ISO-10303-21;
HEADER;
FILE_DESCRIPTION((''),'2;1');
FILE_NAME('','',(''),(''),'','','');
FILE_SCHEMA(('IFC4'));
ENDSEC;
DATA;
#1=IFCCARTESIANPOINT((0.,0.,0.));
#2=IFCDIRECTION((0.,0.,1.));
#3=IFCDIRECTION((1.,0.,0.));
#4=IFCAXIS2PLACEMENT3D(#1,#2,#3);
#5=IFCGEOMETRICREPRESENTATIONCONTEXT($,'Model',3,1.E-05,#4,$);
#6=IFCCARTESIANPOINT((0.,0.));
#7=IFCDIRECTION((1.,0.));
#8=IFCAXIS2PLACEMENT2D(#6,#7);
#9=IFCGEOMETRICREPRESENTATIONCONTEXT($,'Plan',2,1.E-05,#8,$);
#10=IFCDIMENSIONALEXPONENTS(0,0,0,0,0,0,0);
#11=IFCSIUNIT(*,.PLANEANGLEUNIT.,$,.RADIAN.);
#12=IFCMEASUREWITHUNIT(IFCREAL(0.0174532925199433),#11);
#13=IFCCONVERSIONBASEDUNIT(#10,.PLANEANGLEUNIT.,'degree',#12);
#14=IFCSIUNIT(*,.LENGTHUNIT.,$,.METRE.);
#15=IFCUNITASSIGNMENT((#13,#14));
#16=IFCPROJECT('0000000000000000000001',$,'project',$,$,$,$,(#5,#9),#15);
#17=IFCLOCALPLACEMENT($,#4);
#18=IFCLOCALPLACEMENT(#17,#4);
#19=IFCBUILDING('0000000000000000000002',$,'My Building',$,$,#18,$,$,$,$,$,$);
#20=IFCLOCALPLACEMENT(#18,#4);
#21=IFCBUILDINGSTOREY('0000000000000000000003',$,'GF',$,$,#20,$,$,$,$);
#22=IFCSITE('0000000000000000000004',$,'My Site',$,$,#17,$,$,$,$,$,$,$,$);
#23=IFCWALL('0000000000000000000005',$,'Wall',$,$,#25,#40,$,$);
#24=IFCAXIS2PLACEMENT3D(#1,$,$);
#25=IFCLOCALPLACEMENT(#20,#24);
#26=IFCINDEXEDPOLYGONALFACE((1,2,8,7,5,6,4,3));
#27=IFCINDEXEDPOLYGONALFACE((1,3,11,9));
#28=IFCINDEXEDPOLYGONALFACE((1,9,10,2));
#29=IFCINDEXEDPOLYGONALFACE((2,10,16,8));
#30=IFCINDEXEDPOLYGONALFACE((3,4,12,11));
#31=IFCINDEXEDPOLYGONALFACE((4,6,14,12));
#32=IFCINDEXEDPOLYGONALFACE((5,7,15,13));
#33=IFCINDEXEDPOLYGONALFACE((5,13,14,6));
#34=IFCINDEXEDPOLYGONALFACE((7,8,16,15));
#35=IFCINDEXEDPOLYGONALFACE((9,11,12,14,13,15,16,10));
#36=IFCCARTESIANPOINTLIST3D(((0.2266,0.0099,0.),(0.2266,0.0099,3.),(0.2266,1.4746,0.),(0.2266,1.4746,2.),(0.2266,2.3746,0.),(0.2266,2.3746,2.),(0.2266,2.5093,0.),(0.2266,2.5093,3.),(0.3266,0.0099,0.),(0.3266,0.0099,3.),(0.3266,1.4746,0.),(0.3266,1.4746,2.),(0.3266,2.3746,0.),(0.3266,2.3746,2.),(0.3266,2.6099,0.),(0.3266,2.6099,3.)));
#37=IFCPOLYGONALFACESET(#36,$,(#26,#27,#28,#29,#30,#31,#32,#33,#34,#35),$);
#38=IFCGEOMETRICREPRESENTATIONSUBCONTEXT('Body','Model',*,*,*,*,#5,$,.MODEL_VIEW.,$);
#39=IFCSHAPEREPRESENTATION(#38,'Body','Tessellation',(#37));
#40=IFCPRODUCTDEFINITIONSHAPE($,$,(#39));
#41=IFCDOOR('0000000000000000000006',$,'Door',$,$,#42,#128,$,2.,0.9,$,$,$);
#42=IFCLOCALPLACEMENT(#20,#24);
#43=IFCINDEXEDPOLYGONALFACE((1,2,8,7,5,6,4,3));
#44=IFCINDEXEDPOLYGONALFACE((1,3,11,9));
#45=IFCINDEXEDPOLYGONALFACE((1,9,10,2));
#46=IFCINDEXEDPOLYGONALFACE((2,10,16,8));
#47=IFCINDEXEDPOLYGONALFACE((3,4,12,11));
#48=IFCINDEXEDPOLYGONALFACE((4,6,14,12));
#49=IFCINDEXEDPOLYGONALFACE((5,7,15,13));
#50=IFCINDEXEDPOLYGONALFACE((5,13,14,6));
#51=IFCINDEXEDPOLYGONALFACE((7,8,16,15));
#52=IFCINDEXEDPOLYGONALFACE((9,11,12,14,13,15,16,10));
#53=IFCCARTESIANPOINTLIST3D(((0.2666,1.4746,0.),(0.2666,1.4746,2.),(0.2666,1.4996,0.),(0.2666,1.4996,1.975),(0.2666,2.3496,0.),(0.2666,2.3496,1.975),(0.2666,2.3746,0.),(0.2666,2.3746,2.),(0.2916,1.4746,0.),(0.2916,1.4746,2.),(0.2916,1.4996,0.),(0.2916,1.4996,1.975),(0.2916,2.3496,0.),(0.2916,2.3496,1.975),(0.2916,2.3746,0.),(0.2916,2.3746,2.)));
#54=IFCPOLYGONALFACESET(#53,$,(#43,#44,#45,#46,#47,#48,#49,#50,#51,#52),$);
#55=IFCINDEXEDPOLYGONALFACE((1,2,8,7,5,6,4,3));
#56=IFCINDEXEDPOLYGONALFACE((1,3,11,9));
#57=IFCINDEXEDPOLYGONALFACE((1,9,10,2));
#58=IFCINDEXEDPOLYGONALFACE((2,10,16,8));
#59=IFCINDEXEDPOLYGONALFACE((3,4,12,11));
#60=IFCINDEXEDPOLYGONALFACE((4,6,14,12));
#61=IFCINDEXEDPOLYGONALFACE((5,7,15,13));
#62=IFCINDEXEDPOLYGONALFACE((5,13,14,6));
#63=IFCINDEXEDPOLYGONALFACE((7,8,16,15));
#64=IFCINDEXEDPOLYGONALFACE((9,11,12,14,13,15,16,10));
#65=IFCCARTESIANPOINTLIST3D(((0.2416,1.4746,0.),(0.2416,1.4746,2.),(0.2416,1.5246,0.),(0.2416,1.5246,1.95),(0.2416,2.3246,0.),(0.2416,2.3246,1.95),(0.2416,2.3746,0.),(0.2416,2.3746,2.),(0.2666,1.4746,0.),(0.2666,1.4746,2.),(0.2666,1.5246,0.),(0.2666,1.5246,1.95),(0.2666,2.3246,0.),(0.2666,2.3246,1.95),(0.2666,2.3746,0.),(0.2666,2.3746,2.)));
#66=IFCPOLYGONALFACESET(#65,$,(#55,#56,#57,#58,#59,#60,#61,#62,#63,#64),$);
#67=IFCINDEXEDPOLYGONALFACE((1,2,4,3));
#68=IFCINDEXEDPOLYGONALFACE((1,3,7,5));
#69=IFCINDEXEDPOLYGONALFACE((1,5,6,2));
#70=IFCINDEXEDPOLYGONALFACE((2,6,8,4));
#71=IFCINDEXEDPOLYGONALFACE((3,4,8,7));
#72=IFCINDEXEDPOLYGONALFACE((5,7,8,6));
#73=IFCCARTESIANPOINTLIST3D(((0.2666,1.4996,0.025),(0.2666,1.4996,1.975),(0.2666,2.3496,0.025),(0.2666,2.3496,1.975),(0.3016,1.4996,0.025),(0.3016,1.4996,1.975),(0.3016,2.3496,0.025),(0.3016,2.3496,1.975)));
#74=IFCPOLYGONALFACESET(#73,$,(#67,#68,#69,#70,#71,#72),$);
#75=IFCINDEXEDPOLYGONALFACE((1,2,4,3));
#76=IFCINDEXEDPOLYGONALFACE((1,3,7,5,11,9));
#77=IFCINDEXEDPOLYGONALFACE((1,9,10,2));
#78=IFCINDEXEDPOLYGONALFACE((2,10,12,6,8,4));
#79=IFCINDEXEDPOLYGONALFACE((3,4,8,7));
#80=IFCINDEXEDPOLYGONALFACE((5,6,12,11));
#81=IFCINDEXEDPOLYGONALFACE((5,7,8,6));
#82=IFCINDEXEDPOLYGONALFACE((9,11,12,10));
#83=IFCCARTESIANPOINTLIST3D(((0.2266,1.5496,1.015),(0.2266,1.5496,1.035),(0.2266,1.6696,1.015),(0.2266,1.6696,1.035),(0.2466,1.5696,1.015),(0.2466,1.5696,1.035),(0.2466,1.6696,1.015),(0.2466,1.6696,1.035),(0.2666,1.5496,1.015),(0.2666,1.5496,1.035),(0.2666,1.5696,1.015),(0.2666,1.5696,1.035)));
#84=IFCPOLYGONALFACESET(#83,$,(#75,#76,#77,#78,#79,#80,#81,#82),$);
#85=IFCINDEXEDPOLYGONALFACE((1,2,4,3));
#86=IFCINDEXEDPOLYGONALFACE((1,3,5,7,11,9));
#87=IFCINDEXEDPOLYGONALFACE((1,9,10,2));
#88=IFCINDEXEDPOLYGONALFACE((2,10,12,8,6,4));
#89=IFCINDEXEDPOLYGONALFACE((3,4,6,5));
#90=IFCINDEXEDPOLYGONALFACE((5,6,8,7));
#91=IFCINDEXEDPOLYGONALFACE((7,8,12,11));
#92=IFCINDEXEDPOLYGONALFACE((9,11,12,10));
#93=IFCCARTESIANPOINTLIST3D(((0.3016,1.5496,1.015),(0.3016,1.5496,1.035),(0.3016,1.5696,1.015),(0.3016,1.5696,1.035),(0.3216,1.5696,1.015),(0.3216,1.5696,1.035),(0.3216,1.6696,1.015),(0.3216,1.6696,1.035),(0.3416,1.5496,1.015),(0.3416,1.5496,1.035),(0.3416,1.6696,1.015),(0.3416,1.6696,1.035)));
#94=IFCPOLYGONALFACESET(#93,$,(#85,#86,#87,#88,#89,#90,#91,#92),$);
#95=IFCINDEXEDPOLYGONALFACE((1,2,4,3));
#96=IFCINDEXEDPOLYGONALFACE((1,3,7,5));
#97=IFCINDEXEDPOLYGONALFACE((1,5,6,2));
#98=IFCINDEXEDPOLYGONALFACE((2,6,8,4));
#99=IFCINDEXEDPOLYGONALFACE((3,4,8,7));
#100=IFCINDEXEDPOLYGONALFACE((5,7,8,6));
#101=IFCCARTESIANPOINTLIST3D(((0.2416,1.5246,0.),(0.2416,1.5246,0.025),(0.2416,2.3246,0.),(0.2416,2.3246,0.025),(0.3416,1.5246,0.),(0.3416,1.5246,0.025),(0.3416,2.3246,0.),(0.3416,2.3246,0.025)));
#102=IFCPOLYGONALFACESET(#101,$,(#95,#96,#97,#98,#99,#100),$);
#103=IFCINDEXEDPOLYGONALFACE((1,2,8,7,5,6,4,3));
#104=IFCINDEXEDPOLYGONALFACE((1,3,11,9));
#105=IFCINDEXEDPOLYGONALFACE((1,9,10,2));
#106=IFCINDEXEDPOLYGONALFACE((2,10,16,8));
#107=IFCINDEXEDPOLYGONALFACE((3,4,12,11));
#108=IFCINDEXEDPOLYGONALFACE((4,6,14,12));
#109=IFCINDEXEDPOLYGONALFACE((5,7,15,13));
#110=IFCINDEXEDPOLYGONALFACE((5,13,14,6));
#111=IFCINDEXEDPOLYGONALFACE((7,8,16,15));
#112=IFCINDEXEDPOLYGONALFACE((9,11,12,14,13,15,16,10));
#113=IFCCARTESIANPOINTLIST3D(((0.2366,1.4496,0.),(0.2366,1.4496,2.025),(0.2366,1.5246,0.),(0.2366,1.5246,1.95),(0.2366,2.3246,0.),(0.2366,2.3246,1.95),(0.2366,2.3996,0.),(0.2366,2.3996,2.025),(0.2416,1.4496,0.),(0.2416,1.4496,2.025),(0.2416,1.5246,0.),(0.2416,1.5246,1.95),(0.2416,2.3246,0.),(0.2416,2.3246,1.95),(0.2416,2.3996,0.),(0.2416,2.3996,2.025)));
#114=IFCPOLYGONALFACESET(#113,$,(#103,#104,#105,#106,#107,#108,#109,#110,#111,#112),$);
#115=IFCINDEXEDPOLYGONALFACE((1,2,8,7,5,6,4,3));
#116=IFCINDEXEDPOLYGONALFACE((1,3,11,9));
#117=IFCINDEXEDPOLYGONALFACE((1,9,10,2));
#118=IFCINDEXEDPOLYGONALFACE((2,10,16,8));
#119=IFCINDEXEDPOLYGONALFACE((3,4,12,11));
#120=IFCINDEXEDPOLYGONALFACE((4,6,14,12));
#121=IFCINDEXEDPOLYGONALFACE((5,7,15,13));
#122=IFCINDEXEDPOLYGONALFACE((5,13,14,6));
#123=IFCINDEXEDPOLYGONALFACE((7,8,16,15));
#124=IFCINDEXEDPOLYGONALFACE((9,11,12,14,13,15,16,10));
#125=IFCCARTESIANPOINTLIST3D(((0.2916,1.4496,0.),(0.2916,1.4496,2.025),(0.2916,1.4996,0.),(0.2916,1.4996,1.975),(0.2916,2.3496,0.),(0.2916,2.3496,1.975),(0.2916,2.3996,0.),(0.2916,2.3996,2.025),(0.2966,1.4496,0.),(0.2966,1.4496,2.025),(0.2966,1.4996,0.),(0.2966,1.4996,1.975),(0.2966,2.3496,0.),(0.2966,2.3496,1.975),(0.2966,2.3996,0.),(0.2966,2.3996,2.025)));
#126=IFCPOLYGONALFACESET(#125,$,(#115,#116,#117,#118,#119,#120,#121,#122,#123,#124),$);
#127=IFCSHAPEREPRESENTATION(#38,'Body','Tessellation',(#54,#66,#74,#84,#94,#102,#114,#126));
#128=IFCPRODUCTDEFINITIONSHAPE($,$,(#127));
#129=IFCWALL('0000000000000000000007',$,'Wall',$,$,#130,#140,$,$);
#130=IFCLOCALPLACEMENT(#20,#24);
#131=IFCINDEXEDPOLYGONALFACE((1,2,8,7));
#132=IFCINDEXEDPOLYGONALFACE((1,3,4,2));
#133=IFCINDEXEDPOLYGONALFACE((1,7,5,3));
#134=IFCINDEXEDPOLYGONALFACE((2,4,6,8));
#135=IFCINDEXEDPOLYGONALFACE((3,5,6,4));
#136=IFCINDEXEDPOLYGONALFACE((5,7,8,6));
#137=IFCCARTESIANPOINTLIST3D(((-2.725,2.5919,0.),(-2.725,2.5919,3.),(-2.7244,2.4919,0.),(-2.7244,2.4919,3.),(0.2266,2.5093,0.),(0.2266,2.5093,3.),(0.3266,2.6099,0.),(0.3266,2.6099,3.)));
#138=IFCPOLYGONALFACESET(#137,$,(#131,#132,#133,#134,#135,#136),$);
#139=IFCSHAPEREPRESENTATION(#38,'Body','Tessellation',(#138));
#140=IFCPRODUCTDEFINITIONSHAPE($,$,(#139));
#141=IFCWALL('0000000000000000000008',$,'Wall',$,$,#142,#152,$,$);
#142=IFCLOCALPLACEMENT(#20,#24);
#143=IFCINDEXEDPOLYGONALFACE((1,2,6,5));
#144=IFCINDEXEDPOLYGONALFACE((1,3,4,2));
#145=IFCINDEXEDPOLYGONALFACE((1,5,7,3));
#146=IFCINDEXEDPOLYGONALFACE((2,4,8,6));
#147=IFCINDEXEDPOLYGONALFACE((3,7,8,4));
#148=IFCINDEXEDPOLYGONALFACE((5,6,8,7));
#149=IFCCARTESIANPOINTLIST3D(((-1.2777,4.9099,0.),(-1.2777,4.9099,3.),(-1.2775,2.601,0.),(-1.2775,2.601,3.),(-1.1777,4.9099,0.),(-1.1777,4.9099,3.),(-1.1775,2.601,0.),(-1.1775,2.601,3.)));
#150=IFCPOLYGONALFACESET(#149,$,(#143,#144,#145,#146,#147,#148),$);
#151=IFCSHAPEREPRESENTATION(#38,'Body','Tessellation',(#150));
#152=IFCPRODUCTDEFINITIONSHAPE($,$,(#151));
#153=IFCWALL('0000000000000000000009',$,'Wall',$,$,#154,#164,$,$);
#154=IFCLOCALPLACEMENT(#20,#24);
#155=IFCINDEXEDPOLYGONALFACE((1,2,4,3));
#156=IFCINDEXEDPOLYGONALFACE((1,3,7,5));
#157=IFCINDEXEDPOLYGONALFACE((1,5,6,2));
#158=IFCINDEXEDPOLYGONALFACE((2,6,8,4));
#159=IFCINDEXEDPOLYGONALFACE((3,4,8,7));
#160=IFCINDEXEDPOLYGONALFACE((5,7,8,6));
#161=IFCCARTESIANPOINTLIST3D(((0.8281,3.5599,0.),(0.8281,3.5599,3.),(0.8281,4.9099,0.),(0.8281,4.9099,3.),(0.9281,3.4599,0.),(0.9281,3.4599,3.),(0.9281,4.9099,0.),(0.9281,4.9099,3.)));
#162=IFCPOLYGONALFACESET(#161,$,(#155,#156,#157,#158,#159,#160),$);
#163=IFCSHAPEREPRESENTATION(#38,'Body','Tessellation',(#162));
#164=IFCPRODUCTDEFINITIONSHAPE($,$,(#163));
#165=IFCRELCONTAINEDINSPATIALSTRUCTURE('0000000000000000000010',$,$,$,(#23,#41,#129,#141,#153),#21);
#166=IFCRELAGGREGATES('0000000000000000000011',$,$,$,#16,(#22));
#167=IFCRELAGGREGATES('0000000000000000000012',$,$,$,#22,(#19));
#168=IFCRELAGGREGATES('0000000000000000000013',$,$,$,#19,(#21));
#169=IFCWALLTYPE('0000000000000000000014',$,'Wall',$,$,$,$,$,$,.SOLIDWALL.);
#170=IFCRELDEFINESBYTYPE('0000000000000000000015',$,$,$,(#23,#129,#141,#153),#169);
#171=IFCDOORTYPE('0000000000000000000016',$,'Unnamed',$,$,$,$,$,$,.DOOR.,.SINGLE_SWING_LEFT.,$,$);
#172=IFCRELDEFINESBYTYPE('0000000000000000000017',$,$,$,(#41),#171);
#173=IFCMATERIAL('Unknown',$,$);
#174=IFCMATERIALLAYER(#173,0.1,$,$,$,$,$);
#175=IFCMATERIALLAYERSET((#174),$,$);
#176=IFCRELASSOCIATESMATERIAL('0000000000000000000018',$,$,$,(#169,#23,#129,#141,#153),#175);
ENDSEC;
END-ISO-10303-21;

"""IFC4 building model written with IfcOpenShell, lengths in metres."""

from ifc_helpers import new_model, entity, si_unit, converted_unit, frame, origin_with_axes, origin_2d_with_axis, place, context, subcontext, project, spatial, line, indexed_curve, outline, extrude, shape, source, transform, mapped, material, layer, layer_set, layer_usage, type_object, type_shapes, element, fill, save


model = new_model("IFC4")

# Units and contexts
model_context = context("Model", 3, precision=1e-05, world=origin_with_axes())
plan_context = context("Plan", 2, precision=1e-05, world=origin_2d_with_axis())
body_context_1 = subcontext(model_context, "Body", "Model", "MODEL_VIEW")
body_context_2 = subcontext(plan_context, "Body", "Plan", "PLAN_VIEW")
ifc_project = project(units=[converted_unit("PLANEANGLEUNIT", "degree", entity("IfcReal", 0.0174532925199433), si_unit("PLANEANGLEUNIT", "RADIAN"), dimensions=[0, 0, 0, 0, 0, 0, 0]), si_unit("LENGTHUNIT", "METRE")], contexts=[model_context, plan_context])

# Site, building, storey
site_placement = place(None, origin_with_axes())
site = spatial("IfcSite", under=ifc_project, at=site_placement, Name="My Site")
building_placement = place(site_placement, origin_with_axes())
building = spatial("IfcBuilding", under=site, at=building_placement, Name="My Building")
storey_placement = place(building_placement, origin_with_axes())
storey = spatial("IfcBuildingStorey", under=building, at=storey_placement, Name="GF")

# Shared definitions
ifc_material = material(Name="Unknown")

# Shared definitions
ifc_layer_1 = layer(ifc_material, 0.1)
ifc_layer_set_1 = layer_set([ifc_layer_1])
wall_type = type_object("IfcWallType", Name="Wall", PredefinedType="SOLIDWALL", material=ifc_layer_set_1)
shared_shape_1 = source(origin_with_axes(), body_context_1, "Body", "SweptSolid", [
    extrude(outline(indexed_curve([(0.0, 0.0), (0.9, 0.0), (0.9, 2.0), (0.0, 2.0)], segments=[line(1, 2, 3, 4, 1)])), frame((0.0, -0.6, 0.0), z_axis=(0.0, -1.0, 0.0), x_axis=(1.0, 0.0, 0.0)), (0.0, 0.0, -1.0), 1.2),
])
door_type = type_object("IfcDoorType", Name="Unnamed", OperationType="SINGLE_SWING_LEFT", PredefinedType="DOOR")
shared_shape_2 = source(origin_with_axes(), body_context_1, "Body", "SweptSolid", [
    extrude(outline(indexed_curve([(0.0, 0.0), (0.0, 2.0), (0.9, 2.0), (0.9, 0.0), (0.875, 0.0), (0.875, 1.975), (0.025, 1.975), (0.025, 0.0)], segments=[line(1, 2, 3, 4, 5, 6, 7, 8, 1)])), frame((0.0, 0.025, 0.0), z_axis=(0.0, -1.0, 0.0), x_axis=(1.0, 0.0, 0.0)), (0.0, 0.0, -1.0), 0.025),
    extrude(outline(indexed_curve([(0.0, 0.0), (0.0, 2.0), (0.9, 2.0), (0.9, 0.0), (0.85, 0.0), (0.85, 1.95), (0.05, 1.95), (0.05, 0.0)], segments=[line(1, 2, 3, 4, 5, 6, 7, 8, 1)])), frame((0.0, 0.0, 0.0), z_axis=(0.0, -1.0, 0.0), x_axis=(1.0, 0.0, 0.0)), (0.0, 0.0, -1.0), 0.025),
    extrude(outline(indexed_curve([(0.0, 0.0), (0.85, 0.0), (0.85, 0.035), (0.0, 0.035)], segments=[line(1, 2, 3, 4, 1)])), frame((0.025, 0.025, 0.025), z_axis=(0.0, 0.0, 1.0), x_axis=(1.0, 0.0, 0.0)), (0.0, 0.0, 1.0), 1.95),
    extrude(outline(indexed_curve([(0.0, 0.0), (0.0, -0.04), (-0.12, -0.04), (-0.12, -0.02), (-0.02, -0.02), (-0.02, 0.0)], segments=[line(1, 2, 3, 4, 5, 6, 1)])), frame((0.825, 0.025, 1.015), z_axis=(0.0, 0.0, 1.0), x_axis=(1.0, 0.0, 0.0)), (0.0, 0.0, 1.0), 0.02),
    extrude(outline(indexed_curve([(0.0, 0.0), (0.0, 0.04), (-0.12, 0.04), (-0.12, 0.02), (-0.02, 0.02), (-0.02, 0.0)], segments=[line(1, 2, 3, 4, 5, 6, 1)])), frame((0.825, 0.06, 1.015), z_axis=(0.0, 0.0, 1.0), x_axis=(1.0, 0.0, 0.0)), (0.0, 0.0, 1.0), 0.02),
    extrude(outline(indexed_curve([(0.0, 0.0), (0.8, 0.0), (0.8, 0.1), (0.0, 0.1)], segments=[line(1, 2, 3, 4, 1)])), frame((0.05, 0.0, 0.0), z_axis=(0.0, 0.0, 1.0), x_axis=(1.0, 0.0, 0.0)), (0.0, 0.0, 1.0), 0.025),
    extrude(outline(indexed_curve([(0.0, 0.0), (0.0, 2.025), (0.95, 2.025), (0.95, 0.0), (0.875, 0.0), (0.875, 1.95), (0.075, 1.95), (0.075, 0.0)], segments=[line(1, 2, 3, 4, 5, 6, 7, 8, 1)])), frame((-0.025, -0.005, 0.0), z_axis=(0.0, -1.0, 0.0), x_axis=(1.0, 0.0, 0.0)), (0.0, 0.0, -1.0), 0.005),
    extrude(outline(indexed_curve([(0.0, 0.0), (0.0, 2.025), (0.95, 2.025), (0.95, 0.0), (0.9, 0.0), (0.9, 1.975), (0.05, 1.975), (0.05, 0.0)], segments=[line(1, 2, 3, 4, 5, 6, 7, 8, 1)])), frame((-0.025, 0.05, 0.0), z_axis=(0.0, -1.0, 0.0), x_axis=(1.0, 0.0, 0.0)), (0.0, 0.0, -1.0), 0.005),
])
shared_shape_3 = source(origin_with_axes(), body_context_2, "Body", "Curve2D", [
    entity("IfcIndexedPolyCurve", entity("IfcCartesianPointList2D", [[0.0, 0.0], [0.0, 0.05], [0.025, 0.05], [0.025, 0.025], [0.05, 0.025], [0.05, 0.0]]), [entity("IfcLineIndex", [1, 2, 3, 4, 5, 6, 1])]),
    entity("IfcIndexedPolyCurve", entity("IfcCartesianPointList2D", [[0.9, 0.0], [0.9, 0.05], [0.875, 0.05], [0.875, 0.025], [0.85, 0.025], [0.85, 0.0]]), [entity("IfcLineIndex", [1, 2, 3, 4, 5, 6, 1])]),
    entity("IfcTrimmedCurve", entity("IfcEllipse", entity("IfcAxis2Placement2D", entity("IfcCartesianPoint", [0.06, 0.05]), entity("IfcDirection", [1.0, 0.0])), 0.815, 0.85), [entity("IfcCartesianPoint", [0.875, 0.05])], [entity("IfcCartesianPoint", [0.06, 0.9])], True, "CARTESIAN"),
    entity("IfcIndexedPolyCurve", entity("IfcCartesianPointList2D", [[0.025, 0.05], [0.06, 0.05], [0.06, 0.9], [0.025, 0.9]]), [entity("IfcLineIndex", [1, 2, 3, 4, 1])]),
])
type_shapes(door_type, [shared_shape_2, shared_shape_3])

# Wall, opening, door
ifc_layer_usage_1 = layer_usage(ifc_layer_set_1, "AXIS2", "POSITIVE", 0.0)
wall_1_placement = place(storey_placement, frame((0.3266, 0.0099, 0.0), z_axis=(0.0, 0.0, 1.0), x_axis=(0.0, 1.0, 0.0)))
wall_1 = element("IfcWall", 1, at=wall_1_placement, inside=storey, type_object=wall_type, material=ifc_layer_usage_1, Name="Wall", context=body_context_1, shape_type="SweptSolid", body=[
    extrude(outline(indexed_curve([(0.0, 0.0), (0.0, 0.1), (2.4994, 0.1), (2.6, 0.0)], segments=[line(1, 2, 3, 4, 1)])), origin_with_axes(), (0.0, 0.0, 1.0), 3.0),
])
opening_1_placement = place(wall_1_placement, frame((1.4647, 0.0, 0.0), z_axis=(0.0, 0.0, 1.0), x_axis=(1.0, 0.0, 0.0)))
opening_1 = element("IfcOpeningElement", 2, at=opening_1_placement, cuts=wall_1, PredefinedType="OPENING", context=body_context_1, shape_type="MappedRepresentation", body=[
    mapped(shared_shape_1, transform((0.0, 0.0, 0.0), x_axis=(1.0, 0.0, 0.0), y_axis=(0.0, 1.0, 0.0), z_axis=(0.0, 0.0, 1.0), scale=1.0)),
])
door_1_placement = place(opening_1_placement, frame((0.9, 0.085, 0.0), z_axis=(0.0, 0.0, 1.0), x_axis=(-1.0, 0.0, 0.0)))
door_1 = element("IfcDoor", 3, at=door_1_placement, inside=storey, type_object=door_type, Name="Door", OverallHeight=2.0, OverallWidth=0.9, shapes=[
    shape(body_context_1, "Body", "MappedRepresentation", [mapped(shared_shape_2, transform((0.0, 0.0, 0.0), x_axis=(1.0, 0.0, 0.0), y_axis=(0.0, 1.0, 0.0), z_axis=(0.0, 0.0, 1.0), scale=1.0))]),
    shape(body_context_2, "Body", "MappedRepresentation", [mapped(shared_shape_3, transform((0.0, 0.0, 0.0), x_axis=(1.0, 0.0, 0.0), y_axis=(0.0, 1.0, 0.0), z_axis=(0.0, 0.0, 1.0), scale=1.0))]),
])
fill(opening_1, door_1)

# Walls
ifc_layer_usage_2 = layer_usage(ifc_layer_set_1, "AXIS2", "POSITIVE", 0.0)
wall_2_placement = place(storey_placement, frame((0.3266, 2.6099, 0.0), z_axis=(0.0, 0.0, 1.0), x_axis=(-0.999983, -0.005893, 0.0)))
element("IfcWall", 4, at=wall_2_placement, inside=storey, type_object=wall_type, material=ifc_layer_usage_2, Name="Wall", context=body_context_1, shape_type="SweptSolid", body=[
    extrude(outline(indexed_curve([(0.0, 0.0), (0.1006, 0.1), (3.0517, 0.1), (3.0517, 0.0)], segments=[line(1, 2, 3, 4, 1)])), origin_with_axes(), (0.0, 0.0, 1.0), 3.0),
])
ifc_layer_usage_3 = layer_usage(ifc_layer_set_1, "AXIS2", "POSITIVE", 0.0)
wall_3_placement = place(storey_placement, frame((-1.1775, 2.601, 0.0), z_axis=(0.0, 0.0, 1.0), x_axis=(-0.000063, 1.0, 0.0)))
element("IfcWall", 5, at=wall_3_placement, inside=storey, type_object=wall_type, material=ifc_layer_usage_3, Name="Wall", context=body_context_1, shape_type="SweptSolid", body=[
    extrude(outline(indexed_curve([(0.0, 0.0), (0.0, 0.1), (2.3089, 0.1), (2.3089, 0.0)], segments=[line(1, 2, 3, 4, 1)])), origin_with_axes(), (0.0, 0.0, 1.0), 3.0),
])
ifc_layer_usage_4 = layer_usage(ifc_layer_set_1, "AXIS2", "POSITIVE", 0.0)
wall_4_placement = place(storey_placement, frame((0.8281, 4.9099, 0.0), z_axis=(0.0, 0.0, 1.0), x_axis=(0.0, -1.0, 0.0)))
element("IfcWall", 6, at=wall_4_placement, inside=storey, type_object=wall_type, material=ifc_layer_usage_4, Name="Wall", context=body_context_1, shape_type="SweptSolid", body=[
    extrude(outline(indexed_curve([(0.0, 0.0), (0.0, 0.1), (1.45, 0.1), (1.35, 0.0)], segments=[line(1, 2, 3, 4, 1)])), origin_with_axes(), (0.0, 0.0, 1.0), 3.0),
])

save(model, "model.ifc")
